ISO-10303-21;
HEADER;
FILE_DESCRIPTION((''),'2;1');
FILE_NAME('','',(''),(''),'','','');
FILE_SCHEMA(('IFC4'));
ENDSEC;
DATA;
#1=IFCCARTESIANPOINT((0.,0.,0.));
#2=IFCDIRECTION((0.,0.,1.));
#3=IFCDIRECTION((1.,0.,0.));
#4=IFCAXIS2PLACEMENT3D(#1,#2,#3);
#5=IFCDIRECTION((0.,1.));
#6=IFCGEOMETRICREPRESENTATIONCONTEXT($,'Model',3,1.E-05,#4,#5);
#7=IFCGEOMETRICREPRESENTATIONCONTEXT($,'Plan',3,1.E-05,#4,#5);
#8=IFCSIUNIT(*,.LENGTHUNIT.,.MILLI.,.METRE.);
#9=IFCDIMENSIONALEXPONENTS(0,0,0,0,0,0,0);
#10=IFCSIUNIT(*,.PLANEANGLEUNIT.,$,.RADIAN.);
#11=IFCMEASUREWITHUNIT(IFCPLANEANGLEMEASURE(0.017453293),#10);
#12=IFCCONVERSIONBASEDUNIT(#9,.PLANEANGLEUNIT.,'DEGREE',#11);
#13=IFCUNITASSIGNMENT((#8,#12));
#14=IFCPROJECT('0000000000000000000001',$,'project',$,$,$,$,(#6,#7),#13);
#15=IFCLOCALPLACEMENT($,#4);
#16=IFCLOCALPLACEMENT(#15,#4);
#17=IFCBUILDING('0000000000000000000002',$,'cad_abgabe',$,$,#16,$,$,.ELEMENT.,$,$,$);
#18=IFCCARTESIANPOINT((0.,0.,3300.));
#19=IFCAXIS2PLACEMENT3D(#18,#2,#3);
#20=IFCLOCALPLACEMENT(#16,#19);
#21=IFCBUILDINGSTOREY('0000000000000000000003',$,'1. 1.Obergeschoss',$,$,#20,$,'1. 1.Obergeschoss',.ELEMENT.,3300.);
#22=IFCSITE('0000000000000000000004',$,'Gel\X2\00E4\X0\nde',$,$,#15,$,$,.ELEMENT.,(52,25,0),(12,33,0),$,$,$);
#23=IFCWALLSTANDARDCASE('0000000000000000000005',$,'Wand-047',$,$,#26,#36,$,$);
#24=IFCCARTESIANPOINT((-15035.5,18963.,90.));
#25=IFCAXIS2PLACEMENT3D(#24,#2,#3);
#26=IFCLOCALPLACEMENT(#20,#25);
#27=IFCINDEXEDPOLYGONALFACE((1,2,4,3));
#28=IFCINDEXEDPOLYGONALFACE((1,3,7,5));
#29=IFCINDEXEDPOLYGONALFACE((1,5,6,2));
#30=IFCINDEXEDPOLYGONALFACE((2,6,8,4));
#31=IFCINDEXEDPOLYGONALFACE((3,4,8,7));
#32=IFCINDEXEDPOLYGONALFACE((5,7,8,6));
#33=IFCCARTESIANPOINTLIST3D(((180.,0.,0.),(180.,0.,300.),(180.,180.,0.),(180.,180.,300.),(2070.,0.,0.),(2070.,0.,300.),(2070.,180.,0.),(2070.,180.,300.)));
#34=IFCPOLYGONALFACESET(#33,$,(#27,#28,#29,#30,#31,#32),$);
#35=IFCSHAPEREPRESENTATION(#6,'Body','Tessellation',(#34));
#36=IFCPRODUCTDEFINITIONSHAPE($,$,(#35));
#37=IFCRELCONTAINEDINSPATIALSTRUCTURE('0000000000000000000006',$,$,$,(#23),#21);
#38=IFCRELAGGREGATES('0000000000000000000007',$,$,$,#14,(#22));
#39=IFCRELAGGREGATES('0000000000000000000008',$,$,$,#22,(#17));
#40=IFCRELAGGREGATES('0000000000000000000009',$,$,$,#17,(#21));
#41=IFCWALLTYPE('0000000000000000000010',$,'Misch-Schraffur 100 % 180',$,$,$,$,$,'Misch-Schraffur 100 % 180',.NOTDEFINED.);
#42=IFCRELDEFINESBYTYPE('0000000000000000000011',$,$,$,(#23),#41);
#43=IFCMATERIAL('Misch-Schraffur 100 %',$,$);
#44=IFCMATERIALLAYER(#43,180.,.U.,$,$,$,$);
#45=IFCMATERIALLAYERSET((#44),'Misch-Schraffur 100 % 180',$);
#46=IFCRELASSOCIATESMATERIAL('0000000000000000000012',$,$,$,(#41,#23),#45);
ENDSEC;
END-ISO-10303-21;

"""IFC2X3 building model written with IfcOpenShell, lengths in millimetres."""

from ifc_helpers import new_model, entity, si_unit, converted_unit, direction, frame, origin_with_axes, place, context, project, spatial, polyline, outline, extrude, material, layer, layer_set, layer_usage, type_object, element, save


model = new_model("IFC2X3")

# Units and contexts
model_context = context("Model", 3, precision=1e-05, world=origin_with_axes(), true_north=direction((0.0, 1.0)))
plan_context = context("Plan", 3, precision=1e-05, world=origin_with_axes(), true_north=direction((0.0, 1.0)))
ifc_project = project(units=[si_unit("LENGTHUNIT", "METRE", prefix="MILLI"), converted_unit("PLANEANGLEUNIT", "DEGREE", entity("IfcPlaneAngleMeasure", 0.017453293), si_unit("PLANEANGLEUNIT", "RADIAN"), dimensions=[0, 0, 0, 0, 0, 0, 0])], contexts=[model_context, plan_context])

# Site, building, storey
site_placement = place(None, origin_with_axes())
site = spatial("IfcSite", under=ifc_project, at=site_placement, Name="Gelände", CompositionType="ELEMENT", RefLatitude=(52, 25, 0), RefLongitude=(12, 33, 0))
building_placement = place(site_placement, origin_with_axes())
building = spatial("IfcBuilding", under=site, at=building_placement, Name="cad_abgabe", CompositionType="ELEMENT")
storey_placement = place(building_placement, frame((0.0, 0.0, 3300.0), z_axis=(0.0, 0.0, 1.0), x_axis=(1.0, 0.0, 0.0)))
storey = spatial("IfcBuildingStorey", under=building, at=storey_placement, Name="1. 1.Obergeschoss", LongName="1. 1.Obergeschoss", CompositionType="ELEMENT", Elevation=3300.0)

# Wall
ifc_material = material(Name="Misch-Schraffur 100 %")
ifc_layer_1 = layer(ifc_material, 180.0, ventilated="UNKNOWN")
ifc_layer_set_1 = layer_set([ifc_layer_1], Name="Misch-Schraffur 100 % 180")
wall_type_1 = type_object("IfcWallType", Name="Misch-Schraffur 100 % 180", ElementType="Misch-Schraffur 100 % 180", PredefinedType="NOTDEFINED", material=ifc_layer_set_1)
ifc_layer_usage_1 = layer_usage(ifc_layer_set_1, "AXIS2", "POSITIVE", 0.0)
wall_1_placement = place(storey_placement, frame((-15035.5, 18963.0, 90.0), z_axis=(0.0, 0.0, 1.0), x_axis=(1.0, 0.0, 0.0)))
element("IfcWallStandardCase", 1, at=wall_1_placement, inside=storey, type_object=wall_type_1, material=ifc_layer_usage_1, Name="Wand-047", context=model_context, shape_type="SweptSolid", body=[
    extrude(outline(polyline([(180.0, 0.0), (2070.0, 0.0), (2070.0, 180.0), (180.0, 180.0), (180.0, 0.0)])), origin_with_axes(), (0.0, 0.0, 1.0), 300.0),
])

save(model, "model.ifc")
